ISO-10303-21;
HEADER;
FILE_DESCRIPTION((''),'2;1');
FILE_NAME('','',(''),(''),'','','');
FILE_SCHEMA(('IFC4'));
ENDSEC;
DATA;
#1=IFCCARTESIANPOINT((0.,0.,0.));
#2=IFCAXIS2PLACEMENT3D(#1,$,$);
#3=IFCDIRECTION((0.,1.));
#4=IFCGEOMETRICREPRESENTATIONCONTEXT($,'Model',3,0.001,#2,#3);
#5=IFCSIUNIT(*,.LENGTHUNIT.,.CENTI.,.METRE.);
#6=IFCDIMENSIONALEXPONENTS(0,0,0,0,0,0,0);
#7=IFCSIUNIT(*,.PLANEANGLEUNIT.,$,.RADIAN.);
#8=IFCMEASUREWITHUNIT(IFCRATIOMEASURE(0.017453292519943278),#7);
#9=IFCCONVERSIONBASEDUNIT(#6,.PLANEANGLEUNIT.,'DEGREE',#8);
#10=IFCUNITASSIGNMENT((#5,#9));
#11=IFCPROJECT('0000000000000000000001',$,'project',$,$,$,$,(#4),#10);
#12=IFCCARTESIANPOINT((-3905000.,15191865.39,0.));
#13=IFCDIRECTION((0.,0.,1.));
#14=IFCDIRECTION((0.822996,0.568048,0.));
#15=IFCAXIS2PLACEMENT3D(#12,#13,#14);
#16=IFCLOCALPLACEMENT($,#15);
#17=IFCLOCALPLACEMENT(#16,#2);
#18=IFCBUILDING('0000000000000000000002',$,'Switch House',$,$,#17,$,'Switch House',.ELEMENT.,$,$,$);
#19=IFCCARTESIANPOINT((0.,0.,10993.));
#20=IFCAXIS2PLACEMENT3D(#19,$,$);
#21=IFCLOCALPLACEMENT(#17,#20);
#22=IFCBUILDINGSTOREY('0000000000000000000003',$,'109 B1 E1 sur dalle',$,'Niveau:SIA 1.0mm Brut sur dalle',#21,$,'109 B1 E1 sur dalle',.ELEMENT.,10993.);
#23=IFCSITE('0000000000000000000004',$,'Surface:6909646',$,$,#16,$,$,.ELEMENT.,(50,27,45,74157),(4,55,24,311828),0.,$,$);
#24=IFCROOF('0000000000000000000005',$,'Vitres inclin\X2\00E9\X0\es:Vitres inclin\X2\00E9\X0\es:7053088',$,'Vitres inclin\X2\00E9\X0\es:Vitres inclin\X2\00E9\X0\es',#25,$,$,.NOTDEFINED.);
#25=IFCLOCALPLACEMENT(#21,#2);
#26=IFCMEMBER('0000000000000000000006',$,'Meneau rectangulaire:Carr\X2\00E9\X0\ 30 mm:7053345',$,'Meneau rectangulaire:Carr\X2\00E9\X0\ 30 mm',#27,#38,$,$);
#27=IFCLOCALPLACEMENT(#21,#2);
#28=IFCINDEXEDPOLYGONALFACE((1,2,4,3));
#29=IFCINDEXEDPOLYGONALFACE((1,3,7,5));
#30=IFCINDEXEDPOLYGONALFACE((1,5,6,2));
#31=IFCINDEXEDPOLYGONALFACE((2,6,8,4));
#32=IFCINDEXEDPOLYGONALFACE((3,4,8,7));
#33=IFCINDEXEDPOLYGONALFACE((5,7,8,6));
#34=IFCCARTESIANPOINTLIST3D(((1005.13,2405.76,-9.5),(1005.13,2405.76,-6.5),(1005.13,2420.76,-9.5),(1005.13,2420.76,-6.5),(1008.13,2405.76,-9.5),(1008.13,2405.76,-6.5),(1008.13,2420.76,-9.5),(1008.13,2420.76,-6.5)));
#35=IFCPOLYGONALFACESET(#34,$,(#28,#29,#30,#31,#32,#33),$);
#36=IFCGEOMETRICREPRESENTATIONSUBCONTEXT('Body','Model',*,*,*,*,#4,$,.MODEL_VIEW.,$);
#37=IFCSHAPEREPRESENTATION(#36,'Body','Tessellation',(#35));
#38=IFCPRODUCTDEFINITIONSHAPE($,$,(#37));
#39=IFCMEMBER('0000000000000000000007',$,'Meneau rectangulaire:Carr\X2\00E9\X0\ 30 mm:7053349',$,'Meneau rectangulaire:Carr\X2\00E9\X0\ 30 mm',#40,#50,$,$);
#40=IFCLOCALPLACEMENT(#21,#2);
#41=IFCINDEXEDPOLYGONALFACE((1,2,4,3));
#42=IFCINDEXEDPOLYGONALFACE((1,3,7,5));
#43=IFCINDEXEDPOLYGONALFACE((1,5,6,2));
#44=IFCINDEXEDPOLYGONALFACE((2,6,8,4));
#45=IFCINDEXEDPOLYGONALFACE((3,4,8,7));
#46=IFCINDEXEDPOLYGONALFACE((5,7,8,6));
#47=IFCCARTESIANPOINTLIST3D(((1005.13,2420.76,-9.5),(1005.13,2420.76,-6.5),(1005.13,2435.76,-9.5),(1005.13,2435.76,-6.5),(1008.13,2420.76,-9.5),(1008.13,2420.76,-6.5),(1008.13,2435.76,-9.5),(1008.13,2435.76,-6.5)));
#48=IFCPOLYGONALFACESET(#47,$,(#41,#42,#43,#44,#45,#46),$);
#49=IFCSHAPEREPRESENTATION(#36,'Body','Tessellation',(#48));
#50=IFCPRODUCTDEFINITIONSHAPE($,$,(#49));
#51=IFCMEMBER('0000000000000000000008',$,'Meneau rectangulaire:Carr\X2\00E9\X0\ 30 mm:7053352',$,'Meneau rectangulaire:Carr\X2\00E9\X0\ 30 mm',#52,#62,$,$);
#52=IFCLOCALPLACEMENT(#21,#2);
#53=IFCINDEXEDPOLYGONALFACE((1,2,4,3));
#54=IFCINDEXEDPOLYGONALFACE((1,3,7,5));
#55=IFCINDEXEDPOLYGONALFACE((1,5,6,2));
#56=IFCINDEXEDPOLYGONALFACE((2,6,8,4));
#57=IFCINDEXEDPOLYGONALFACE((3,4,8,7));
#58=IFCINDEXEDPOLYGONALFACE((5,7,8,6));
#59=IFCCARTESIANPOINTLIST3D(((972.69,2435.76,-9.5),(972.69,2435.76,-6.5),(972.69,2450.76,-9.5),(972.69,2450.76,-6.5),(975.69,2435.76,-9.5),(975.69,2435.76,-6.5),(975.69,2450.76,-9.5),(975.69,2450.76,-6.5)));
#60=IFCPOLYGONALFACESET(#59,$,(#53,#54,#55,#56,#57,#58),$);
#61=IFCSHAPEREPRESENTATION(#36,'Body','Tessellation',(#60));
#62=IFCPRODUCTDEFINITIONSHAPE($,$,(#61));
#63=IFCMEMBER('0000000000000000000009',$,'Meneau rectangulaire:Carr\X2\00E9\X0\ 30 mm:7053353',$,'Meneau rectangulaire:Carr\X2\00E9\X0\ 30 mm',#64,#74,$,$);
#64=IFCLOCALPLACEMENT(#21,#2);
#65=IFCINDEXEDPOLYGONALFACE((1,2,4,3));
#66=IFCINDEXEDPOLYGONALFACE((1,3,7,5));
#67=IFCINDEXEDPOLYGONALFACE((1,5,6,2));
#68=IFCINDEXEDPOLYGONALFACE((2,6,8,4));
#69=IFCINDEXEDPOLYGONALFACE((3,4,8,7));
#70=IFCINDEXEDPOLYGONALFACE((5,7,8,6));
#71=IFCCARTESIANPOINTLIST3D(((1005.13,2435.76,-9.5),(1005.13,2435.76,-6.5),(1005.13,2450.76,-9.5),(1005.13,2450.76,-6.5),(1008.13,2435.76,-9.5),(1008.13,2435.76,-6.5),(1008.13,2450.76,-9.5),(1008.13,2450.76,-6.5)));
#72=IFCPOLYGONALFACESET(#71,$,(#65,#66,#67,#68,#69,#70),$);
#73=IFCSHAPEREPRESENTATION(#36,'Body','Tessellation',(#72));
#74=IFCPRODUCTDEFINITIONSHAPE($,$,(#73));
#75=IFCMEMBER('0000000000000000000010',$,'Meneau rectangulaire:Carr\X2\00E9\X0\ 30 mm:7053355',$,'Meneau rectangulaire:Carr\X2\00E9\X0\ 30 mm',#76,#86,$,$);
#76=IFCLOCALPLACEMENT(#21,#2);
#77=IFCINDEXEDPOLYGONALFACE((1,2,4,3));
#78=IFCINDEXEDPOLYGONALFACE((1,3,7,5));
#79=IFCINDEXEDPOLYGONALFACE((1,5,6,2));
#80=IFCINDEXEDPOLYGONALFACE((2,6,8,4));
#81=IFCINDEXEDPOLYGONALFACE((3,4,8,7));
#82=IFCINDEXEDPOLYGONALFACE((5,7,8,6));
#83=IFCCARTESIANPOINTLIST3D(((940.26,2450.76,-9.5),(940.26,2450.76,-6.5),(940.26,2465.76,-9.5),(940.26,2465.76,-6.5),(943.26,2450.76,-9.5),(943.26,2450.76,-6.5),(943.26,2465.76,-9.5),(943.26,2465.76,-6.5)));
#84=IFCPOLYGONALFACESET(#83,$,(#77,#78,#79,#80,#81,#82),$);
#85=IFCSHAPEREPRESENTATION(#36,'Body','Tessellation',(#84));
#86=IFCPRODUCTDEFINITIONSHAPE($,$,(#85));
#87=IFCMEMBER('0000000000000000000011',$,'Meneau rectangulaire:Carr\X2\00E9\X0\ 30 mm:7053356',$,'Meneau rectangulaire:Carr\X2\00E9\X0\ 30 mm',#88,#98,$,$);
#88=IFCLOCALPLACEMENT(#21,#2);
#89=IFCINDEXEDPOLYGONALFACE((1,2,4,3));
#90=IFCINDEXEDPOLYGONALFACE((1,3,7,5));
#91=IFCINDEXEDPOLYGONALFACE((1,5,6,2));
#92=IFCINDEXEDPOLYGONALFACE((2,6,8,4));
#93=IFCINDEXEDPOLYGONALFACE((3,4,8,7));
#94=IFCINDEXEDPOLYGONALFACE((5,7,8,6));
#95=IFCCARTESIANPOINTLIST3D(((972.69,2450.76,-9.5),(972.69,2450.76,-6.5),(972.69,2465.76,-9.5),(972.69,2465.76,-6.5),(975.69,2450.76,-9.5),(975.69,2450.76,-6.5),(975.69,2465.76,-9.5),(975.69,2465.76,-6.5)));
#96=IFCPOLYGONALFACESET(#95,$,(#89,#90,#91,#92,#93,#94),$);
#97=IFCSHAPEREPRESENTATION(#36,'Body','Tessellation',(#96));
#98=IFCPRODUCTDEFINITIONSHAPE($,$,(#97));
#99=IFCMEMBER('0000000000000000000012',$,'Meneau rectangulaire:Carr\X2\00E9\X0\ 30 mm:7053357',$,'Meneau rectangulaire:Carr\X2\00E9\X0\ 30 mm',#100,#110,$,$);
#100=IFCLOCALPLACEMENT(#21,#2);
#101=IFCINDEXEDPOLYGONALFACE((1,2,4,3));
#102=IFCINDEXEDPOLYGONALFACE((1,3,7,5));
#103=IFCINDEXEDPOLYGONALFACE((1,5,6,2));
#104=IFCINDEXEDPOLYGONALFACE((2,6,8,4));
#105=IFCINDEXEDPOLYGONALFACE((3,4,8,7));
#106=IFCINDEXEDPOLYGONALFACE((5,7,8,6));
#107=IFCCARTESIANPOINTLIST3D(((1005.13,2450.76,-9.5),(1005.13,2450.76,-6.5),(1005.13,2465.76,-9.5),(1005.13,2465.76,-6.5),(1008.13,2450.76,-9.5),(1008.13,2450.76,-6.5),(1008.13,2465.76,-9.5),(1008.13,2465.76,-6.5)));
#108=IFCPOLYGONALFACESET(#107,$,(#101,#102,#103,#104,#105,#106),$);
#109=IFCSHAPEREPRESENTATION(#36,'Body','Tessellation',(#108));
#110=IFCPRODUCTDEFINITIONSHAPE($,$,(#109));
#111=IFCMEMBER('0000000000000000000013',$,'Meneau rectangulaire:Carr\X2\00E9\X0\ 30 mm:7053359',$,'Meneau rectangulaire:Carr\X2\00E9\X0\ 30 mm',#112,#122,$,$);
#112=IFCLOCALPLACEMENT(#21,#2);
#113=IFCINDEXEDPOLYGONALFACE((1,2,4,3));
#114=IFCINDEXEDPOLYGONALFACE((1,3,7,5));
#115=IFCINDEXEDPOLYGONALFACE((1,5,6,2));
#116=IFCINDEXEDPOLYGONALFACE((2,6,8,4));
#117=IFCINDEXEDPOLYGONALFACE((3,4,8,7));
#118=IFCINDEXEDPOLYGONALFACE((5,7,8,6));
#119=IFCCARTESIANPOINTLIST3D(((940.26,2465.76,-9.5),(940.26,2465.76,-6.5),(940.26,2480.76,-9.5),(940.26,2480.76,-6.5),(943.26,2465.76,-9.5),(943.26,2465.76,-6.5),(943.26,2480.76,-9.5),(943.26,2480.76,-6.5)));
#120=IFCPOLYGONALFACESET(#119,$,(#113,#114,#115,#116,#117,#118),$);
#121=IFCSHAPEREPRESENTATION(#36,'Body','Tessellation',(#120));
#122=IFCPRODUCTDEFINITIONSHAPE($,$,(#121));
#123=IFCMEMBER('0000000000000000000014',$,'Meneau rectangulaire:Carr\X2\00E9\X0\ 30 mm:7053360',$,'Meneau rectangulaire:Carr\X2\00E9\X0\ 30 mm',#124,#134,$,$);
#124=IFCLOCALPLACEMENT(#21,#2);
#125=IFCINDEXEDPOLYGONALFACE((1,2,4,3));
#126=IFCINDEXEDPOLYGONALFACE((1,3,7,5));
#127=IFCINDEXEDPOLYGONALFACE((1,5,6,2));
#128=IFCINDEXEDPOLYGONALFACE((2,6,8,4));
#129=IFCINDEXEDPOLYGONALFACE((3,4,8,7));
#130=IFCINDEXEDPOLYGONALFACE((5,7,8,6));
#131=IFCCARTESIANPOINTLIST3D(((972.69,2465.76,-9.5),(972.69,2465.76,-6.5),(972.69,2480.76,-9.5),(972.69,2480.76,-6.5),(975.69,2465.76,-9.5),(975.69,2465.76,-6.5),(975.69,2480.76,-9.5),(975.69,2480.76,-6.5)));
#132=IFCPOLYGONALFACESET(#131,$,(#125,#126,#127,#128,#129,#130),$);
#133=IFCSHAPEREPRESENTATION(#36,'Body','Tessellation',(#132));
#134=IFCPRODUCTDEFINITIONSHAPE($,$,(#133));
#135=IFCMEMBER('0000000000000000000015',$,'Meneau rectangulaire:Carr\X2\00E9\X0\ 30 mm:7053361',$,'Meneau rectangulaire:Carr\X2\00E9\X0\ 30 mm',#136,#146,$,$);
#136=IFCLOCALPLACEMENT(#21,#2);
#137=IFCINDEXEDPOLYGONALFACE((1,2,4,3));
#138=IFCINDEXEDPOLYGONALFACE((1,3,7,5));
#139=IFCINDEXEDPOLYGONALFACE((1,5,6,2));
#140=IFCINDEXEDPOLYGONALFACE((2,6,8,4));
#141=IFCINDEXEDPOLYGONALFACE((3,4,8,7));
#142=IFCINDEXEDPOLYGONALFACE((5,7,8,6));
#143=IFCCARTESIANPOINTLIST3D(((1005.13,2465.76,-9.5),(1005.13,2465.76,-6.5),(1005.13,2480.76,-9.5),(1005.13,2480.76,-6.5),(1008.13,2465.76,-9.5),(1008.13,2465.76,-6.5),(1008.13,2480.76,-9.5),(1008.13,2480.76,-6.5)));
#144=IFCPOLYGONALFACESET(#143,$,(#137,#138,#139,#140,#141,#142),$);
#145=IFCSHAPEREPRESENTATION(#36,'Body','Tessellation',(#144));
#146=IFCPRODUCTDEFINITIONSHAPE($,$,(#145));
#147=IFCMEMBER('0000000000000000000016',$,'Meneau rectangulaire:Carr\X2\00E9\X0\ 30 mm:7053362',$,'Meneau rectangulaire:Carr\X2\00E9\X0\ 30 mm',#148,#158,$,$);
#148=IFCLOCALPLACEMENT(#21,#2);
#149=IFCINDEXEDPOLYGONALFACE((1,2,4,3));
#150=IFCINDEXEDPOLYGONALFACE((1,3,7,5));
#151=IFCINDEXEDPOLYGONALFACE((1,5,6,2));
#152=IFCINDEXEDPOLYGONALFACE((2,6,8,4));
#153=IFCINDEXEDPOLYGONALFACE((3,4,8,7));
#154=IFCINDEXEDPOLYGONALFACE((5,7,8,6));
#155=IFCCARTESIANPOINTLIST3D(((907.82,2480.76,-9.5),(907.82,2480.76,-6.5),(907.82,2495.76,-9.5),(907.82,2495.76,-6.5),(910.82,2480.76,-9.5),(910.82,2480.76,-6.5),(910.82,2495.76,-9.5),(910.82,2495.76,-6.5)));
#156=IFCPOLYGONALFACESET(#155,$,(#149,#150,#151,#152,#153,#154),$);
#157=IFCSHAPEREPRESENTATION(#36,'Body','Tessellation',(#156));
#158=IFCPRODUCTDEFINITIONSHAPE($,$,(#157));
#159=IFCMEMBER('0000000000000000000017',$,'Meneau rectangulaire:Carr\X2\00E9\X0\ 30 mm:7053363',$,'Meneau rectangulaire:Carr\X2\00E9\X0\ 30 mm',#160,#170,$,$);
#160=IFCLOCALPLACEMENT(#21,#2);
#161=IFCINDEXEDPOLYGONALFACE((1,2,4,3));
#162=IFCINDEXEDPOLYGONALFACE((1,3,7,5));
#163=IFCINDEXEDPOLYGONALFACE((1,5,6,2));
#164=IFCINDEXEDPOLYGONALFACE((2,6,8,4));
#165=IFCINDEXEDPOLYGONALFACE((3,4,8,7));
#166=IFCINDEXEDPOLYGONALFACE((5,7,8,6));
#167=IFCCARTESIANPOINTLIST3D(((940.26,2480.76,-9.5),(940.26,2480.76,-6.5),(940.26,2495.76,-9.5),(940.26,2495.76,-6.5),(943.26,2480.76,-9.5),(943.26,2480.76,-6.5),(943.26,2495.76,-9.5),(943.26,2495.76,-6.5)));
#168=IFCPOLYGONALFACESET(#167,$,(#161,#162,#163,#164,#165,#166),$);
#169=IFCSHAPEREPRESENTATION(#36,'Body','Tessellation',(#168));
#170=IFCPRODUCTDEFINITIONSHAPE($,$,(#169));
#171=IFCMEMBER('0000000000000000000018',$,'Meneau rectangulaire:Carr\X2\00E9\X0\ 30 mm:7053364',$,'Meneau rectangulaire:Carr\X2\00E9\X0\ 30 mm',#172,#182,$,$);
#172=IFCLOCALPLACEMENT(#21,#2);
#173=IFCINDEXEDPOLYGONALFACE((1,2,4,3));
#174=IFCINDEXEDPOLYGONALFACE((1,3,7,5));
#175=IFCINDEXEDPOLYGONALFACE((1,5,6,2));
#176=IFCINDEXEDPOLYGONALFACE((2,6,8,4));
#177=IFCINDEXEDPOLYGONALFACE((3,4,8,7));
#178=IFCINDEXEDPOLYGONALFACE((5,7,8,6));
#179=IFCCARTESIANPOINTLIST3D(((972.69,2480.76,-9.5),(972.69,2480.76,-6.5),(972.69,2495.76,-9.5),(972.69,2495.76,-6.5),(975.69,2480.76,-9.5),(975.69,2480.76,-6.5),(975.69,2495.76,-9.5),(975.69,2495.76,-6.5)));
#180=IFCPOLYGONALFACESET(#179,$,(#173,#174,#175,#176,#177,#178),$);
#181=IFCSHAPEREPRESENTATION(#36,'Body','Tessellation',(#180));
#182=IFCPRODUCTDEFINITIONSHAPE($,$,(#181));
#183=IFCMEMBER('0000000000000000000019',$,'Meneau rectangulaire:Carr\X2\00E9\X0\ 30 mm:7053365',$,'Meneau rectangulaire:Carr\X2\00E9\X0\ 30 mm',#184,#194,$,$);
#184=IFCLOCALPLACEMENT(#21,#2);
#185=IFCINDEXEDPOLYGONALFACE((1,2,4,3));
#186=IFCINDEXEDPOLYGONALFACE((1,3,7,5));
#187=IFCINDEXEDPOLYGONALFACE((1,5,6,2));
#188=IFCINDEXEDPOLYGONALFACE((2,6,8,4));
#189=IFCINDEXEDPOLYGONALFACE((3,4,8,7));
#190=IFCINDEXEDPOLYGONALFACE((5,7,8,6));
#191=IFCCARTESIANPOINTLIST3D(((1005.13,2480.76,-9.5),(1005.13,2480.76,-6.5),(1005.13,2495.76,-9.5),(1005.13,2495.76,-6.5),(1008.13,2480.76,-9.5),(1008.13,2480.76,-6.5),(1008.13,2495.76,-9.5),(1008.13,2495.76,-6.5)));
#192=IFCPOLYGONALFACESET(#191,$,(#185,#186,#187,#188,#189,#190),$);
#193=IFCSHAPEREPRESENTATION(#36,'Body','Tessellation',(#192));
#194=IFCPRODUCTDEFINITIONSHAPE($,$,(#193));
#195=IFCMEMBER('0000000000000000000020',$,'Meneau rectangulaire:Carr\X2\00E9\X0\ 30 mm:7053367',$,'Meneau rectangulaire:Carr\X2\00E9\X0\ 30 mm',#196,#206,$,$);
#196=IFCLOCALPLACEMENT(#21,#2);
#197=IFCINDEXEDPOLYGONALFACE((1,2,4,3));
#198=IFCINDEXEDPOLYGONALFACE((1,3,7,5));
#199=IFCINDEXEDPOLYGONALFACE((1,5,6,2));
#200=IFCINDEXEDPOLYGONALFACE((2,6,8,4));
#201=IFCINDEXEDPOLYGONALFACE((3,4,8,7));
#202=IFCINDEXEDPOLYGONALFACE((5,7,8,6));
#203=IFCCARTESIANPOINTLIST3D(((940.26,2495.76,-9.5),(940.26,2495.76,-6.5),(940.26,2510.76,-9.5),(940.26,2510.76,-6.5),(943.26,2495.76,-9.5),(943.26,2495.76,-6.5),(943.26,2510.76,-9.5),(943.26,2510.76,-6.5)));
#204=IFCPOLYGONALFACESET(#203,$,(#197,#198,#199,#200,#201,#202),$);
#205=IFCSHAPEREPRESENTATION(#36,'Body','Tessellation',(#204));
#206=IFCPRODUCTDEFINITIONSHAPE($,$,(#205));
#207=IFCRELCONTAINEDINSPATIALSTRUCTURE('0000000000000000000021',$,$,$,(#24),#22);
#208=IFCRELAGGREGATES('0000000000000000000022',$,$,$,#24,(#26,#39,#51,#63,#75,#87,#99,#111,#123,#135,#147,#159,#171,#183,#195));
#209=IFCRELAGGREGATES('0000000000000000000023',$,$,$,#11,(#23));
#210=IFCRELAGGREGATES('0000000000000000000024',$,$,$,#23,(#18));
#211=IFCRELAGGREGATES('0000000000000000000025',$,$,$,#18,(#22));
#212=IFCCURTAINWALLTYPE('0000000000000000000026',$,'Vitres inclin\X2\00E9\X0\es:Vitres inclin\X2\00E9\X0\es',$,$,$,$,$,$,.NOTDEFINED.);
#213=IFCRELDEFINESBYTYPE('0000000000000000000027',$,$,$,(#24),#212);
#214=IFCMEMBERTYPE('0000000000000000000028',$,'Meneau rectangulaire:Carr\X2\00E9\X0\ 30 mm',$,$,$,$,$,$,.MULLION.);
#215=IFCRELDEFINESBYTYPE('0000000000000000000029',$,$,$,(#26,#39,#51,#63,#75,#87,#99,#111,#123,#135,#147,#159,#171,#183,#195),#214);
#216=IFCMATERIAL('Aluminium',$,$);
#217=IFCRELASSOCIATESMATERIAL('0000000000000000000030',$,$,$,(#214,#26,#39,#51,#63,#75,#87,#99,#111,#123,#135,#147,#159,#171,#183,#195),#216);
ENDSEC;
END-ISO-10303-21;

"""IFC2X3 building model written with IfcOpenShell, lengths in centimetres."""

from ifc_helpers import new_model, entity, si_unit, converted_unit, direction, frame, origin, origin_2d_with_axis, place, context, subcontext, project, spatial, rectangle, extrude, source, transform, mapped, material, type_object, type_shapes, element, aggregate, save


model = new_model("IFC2X3")

# Units and contexts
model_context = context("Model", 3, precision=0.001, world=origin(), true_north=direction((0.0, 1.0)))
body_context = subcontext(model_context, "Body", "Model", "MODEL_VIEW")
ifc_project = project(units=[si_unit("LENGTHUNIT", "METRE", prefix="CENTI"), converted_unit("PLANEANGLEUNIT", "DEGREE", entity("IfcRatioMeasure", 0.017453292519943278), si_unit("PLANEANGLEUNIT", "RADIAN"), dimensions=[0, 0, 0, 0, 0, 0, 0])], contexts=[model_context])

# Site, building, storey
site_placement = place(None, frame((-3905000.0, 15191865.39, 0.0), z_axis=(0.0, 0.0, 1.0), x_axis=(0.822996, 0.568048, 0.0)))
site = spatial("IfcSite", under=ifc_project, at=site_placement, Name="Surface:6909646", CompositionType="ELEMENT", RefLatitude=(50, 27, 45, 74157), RefLongitude=(4, 55, 24, 311828), RefElevation=0.0)
building_placement = place(site_placement, origin())
building = spatial("IfcBuilding", under=site, at=building_placement, Name="Switch House", LongName="Switch House", CompositionType="ELEMENT")
storey_placement = place(building_placement, frame((0.0, 0.0, 10993.0)))
storey = spatial("IfcBuildingStorey", under=building, at=storey_placement, Name="109 B1 E1 sur dalle", ObjectType="Niveau:SIA 1.0mm Brut sur dalle", LongName="109 B1 E1 sur dalle", CompositionType="ELEMENT", Elevation=10993.0)

# Roof, members
curtain_wall_type = type_object("IfcCurtainWallType", Name="Vitres inclinées:Vitres inclinées", PredefinedType="NOTDEFINED")
roof_placement = place(storey_placement, frame((0.0, 0.0, -10993.0)))
roof = element("IfcRoof", 1, at=roof_placement, inside=storey, type_object=curtain_wall_type, Name="Vitres inclinées:Vitres inclinées:7053088", ObjectType="Vitres inclinées:Vitres inclinées", ShapeType="NOTDEFINED")
ifc_material = material(Name="Aluminium")
member_type_1 = type_object("IfcMemberType", Name="Meneau rectangulaire:Carré 30 mm", PredefinedType="MULLION", material=ifc_material)
shared_shape_1 = source(origin(), body_context, "Body", "SweptSolid", [
    extrude(rectangle(XDim=3.0, YDim=3.0, at=origin_2d_with_axis()), frame((0.0, 0.0, -15.0), z_axis=(0.0, 0.0, 1.0), x_axis=(0.0, -1.0, 0.0)), (0.0, 0.0, 1.0), 15.0),
])
type_shapes(member_type_1, [shared_shape_1])
member_1_placement = place(roof_placement, frame((1006.63, 2420.76, 10985.0), z_axis=(0.0, 1.0, 0.0), x_axis=(1.0, 0.0, 0.0)))
member_1 = element("IfcMember", 2, at=member_1_placement, type_object=member_type_1, material=ifc_material, Name="Meneau rectangulaire:Carré 30 mm:7053345", ObjectType="Meneau rectangulaire:Carré 30 mm", context=body_context, shape_type="MappedRepresentation", body=[
    mapped(shared_shape_1, transform((0.0, 0.0, 0.0), scale=1.0)),
])
member_2_placement = place(roof_placement, frame((1006.63, 2435.76, 10985.0), z_axis=(0.0, 1.0, 0.0), x_axis=(1.0, 0.0, 0.0)))
member_2 = element("IfcMember", 3, at=member_2_placement, type_object=member_type_1, material=ifc_material, Name="Meneau rectangulaire:Carré 30 mm:7053349", ObjectType="Meneau rectangulaire:Carré 30 mm", context=body_context, shape_type="MappedRepresentation", body=[
    mapped(shared_shape_1, transform((0.0, 0.0, 0.0), scale=1.0)),
])
member_3_placement = place(roof_placement, frame((974.19, 2450.76, 10985.0), z_axis=(0.0, 1.0, 0.0), x_axis=(1.0, 0.0, 0.0)))
member_3 = element("IfcMember", 4, at=member_3_placement, type_object=member_type_1, material=ifc_material, Name="Meneau rectangulaire:Carré 30 mm:7053352", ObjectType="Meneau rectangulaire:Carré 30 mm", context=body_context, shape_type="MappedRepresentation", body=[
    mapped(shared_shape_1, transform((0.0, 0.0, 0.0), scale=1.0)),
])
member_4_placement = place(roof_placement, frame((1006.63, 2450.76, 10985.0), z_axis=(0.0, 1.0, 0.0), x_axis=(1.0, 0.0, 0.0)))
member_4 = element("IfcMember", 5, at=member_4_placement, type_object=member_type_1, material=ifc_material, Name="Meneau rectangulaire:Carré 30 mm:7053353", ObjectType="Meneau rectangulaire:Carré 30 mm", context=body_context, shape_type="MappedRepresentation", body=[
    mapped(shared_shape_1, transform((0.0, 0.0, 0.0), scale=1.0)),
])
member_5_placement = place(roof_placement, frame((941.76, 2465.76, 10985.0), z_axis=(0.0, 1.0, 0.0), x_axis=(1.0, 0.0, 0.0)))
member_5 = element("IfcMember", 6, at=member_5_placement, type_object=member_type_1, material=ifc_material, Name="Meneau rectangulaire:Carré 30 mm:7053355", ObjectType="Meneau rectangulaire:Carré 30 mm", context=body_context, shape_type="MappedRepresentation", body=[
    mapped(shared_shape_1, transform((0.0, 0.0, 0.0), scale=1.0)),
])
member_6_placement = place(roof_placement, frame((974.19, 2465.76, 10985.0), z_axis=(0.0, 1.0, 0.0), x_axis=(1.0, 0.0, 0.0)))
member_6 = element("IfcMember", 7, at=member_6_placement, type_object=member_type_1, material=ifc_material, Name="Meneau rectangulaire:Carré 30 mm:7053356", ObjectType="Meneau rectangulaire:Carré 30 mm", context=body_context, shape_type="MappedRepresentation", body=[
    mapped(shared_shape_1, transform((0.0, 0.0, 0.0), scale=1.0)),
])
member_7_placement = place(roof_placement, frame((1006.63, 2465.76, 10985.0), z_axis=(0.0, 1.0, 0.0), x_axis=(1.0, 0.0, 0.0)))
member_7 = element("IfcMember", 8, at=member_7_placement, type_object=member_type_1, material=ifc_material, Name="Meneau rectangulaire:Carré 30 mm:7053357", ObjectType="Meneau rectangulaire:Carré 30 mm", context=body_context, shape_type="MappedRepresentation", body=[
    mapped(shared_shape_1, transform((0.0, 0.0, 0.0), scale=1.0)),
])
member_8_placement = place(roof_placement, frame((941.76, 2480.76, 10985.0), z_axis=(0.0, 1.0, 0.0), x_axis=(1.0, 0.0, 0.0)))
member_8 = element("IfcMember", 9, at=member_8_placement, type_object=member_type_1, material=ifc_material, Name="Meneau rectangulaire:Carré 30 mm:7053359", ObjectType="Meneau rectangulaire:Carré 30 mm", context=body_context, shape_type="MappedRepresentation", body=[
    mapped(shared_shape_1, transform((0.0, 0.0, 0.0), scale=1.0)),
])
member_9_placement = place(roof_placement, frame((974.19, 2480.76, 10985.0), z_axis=(0.0, 1.0, 0.0), x_axis=(1.0, 0.0, 0.0)))
member_9 = element("IfcMember", 10, at=member_9_placement, type_object=member_type_1, material=ifc_material, Name="Meneau rectangulaire:Carré 30 mm:7053360", ObjectType="Meneau rectangulaire:Carré 30 mm", context=body_context, shape_type="MappedRepresentation", body=[
    mapped(shared_shape_1, transform((0.0, 0.0, 0.0), scale=1.0)),
])
member_10_placement = place(roof_placement, frame((1006.63, 2480.76, 10985.0), z_axis=(0.0, 1.0, 0.0), x_axis=(1.0, 0.0, 0.0)))
member_10 = element("IfcMember", 11, at=member_10_placement, type_object=member_type_1, material=ifc_material, Name="Meneau rectangulaire:Carré 30 mm:7053361", ObjectType="Meneau rectangulaire:Carré 30 mm", context=body_context, shape_type="MappedRepresentation", body=[
    mapped(shared_shape_1, transform((0.0, 0.0, 0.0), scale=1.0)),
])
member_11_placement = place(roof_placement, frame((909.32, 2495.76, 10985.0), z_axis=(0.0, 1.0, 0.0), x_axis=(1.0, 0.0, 0.0)))
member_11 = element("IfcMember", 12, at=member_11_placement, type_object=member_type_1, material=ifc_material, Name="Meneau rectangulaire:Carré 30 mm:7053362", ObjectType="Meneau rectangulaire:Carré 30 mm", context=body_context, shape_type="MappedRepresentation", body=[
    mapped(shared_shape_1, transform((0.0, 0.0, 0.0), scale=1.0)),
])
member_12_placement = place(roof_placement, frame((941.76, 2495.76, 10985.0), z_axis=(0.0, 1.0, 0.0), x_axis=(1.0, 0.0, 0.0)))
member_12 = element("IfcMember", 13, at=member_12_placement, type_object=member_type_1, material=ifc_material, Name="Meneau rectangulaire:Carré 30 mm:7053363", ObjectType="Meneau rectangulaire:Carré 30 mm", context=body_context, shape_type="MappedRepresentation", body=[
    mapped(shared_shape_1, transform((0.0, 0.0, 0.0), scale=1.0)),
])
member_13_placement = place(roof_placement, frame((974.19, 2495.76, 10985.0), z_axis=(0.0, 1.0, 0.0), x_axis=(1.0, 0.0, 0.0)))
member_13 = element("IfcMember", 14, at=member_13_placement, type_object=member_type_1, material=ifc_material, Name="Meneau rectangulaire:Carré 30 mm:7053364", ObjectType="Meneau rectangulaire:Carré 30 mm", context=body_context, shape_type="MappedRepresentation", body=[
    mapped(shared_shape_1, transform((0.0, 0.0, 0.0), scale=1.0)),
])
member_14_placement = place(roof_placement, frame((1006.63, 2495.76, 10985.0), z_axis=(0.0, 1.0, 0.0), x_axis=(1.0, 0.0, 0.0)))
member_14 = element("IfcMember", 15, at=member_14_placement, type_object=member_type_1, material=ifc_material, Name="Meneau rectangulaire:Carré 30 mm:7053365", ObjectType="Meneau rectangulaire:Carré 30 mm", context=body_context, shape_type="MappedRepresentation", body=[
    mapped(shared_shape_1, transform((0.0, 0.0, 0.0), scale=1.0)),
])
member_15_placement = place(roof_placement, frame((941.76, 2510.76, 10985.0), z_axis=(0.0, 1.0, 0.0), x_axis=(1.0, 0.0, 0.0)))
member_15 = element("IfcMember", 16, at=member_15_placement, type_object=member_type_1, material=ifc_material, Name="Meneau rectangulaire:Carré 30 mm:7053367", ObjectType="Meneau rectangulaire:Carré 30 mm", context=body_context, shape_type="MappedRepresentation", body=[
    mapped(shared_shape_1, transform((0.0, 0.0, 0.0), scale=1.0)),
])
aggregate(roof, [member_1, member_2, member_3, member_4, member_5, member_6, member_7, member_8, member_9, member_10, member_11, member_12, member_13, member_14, member_15])

save(model, "model.ifc")
